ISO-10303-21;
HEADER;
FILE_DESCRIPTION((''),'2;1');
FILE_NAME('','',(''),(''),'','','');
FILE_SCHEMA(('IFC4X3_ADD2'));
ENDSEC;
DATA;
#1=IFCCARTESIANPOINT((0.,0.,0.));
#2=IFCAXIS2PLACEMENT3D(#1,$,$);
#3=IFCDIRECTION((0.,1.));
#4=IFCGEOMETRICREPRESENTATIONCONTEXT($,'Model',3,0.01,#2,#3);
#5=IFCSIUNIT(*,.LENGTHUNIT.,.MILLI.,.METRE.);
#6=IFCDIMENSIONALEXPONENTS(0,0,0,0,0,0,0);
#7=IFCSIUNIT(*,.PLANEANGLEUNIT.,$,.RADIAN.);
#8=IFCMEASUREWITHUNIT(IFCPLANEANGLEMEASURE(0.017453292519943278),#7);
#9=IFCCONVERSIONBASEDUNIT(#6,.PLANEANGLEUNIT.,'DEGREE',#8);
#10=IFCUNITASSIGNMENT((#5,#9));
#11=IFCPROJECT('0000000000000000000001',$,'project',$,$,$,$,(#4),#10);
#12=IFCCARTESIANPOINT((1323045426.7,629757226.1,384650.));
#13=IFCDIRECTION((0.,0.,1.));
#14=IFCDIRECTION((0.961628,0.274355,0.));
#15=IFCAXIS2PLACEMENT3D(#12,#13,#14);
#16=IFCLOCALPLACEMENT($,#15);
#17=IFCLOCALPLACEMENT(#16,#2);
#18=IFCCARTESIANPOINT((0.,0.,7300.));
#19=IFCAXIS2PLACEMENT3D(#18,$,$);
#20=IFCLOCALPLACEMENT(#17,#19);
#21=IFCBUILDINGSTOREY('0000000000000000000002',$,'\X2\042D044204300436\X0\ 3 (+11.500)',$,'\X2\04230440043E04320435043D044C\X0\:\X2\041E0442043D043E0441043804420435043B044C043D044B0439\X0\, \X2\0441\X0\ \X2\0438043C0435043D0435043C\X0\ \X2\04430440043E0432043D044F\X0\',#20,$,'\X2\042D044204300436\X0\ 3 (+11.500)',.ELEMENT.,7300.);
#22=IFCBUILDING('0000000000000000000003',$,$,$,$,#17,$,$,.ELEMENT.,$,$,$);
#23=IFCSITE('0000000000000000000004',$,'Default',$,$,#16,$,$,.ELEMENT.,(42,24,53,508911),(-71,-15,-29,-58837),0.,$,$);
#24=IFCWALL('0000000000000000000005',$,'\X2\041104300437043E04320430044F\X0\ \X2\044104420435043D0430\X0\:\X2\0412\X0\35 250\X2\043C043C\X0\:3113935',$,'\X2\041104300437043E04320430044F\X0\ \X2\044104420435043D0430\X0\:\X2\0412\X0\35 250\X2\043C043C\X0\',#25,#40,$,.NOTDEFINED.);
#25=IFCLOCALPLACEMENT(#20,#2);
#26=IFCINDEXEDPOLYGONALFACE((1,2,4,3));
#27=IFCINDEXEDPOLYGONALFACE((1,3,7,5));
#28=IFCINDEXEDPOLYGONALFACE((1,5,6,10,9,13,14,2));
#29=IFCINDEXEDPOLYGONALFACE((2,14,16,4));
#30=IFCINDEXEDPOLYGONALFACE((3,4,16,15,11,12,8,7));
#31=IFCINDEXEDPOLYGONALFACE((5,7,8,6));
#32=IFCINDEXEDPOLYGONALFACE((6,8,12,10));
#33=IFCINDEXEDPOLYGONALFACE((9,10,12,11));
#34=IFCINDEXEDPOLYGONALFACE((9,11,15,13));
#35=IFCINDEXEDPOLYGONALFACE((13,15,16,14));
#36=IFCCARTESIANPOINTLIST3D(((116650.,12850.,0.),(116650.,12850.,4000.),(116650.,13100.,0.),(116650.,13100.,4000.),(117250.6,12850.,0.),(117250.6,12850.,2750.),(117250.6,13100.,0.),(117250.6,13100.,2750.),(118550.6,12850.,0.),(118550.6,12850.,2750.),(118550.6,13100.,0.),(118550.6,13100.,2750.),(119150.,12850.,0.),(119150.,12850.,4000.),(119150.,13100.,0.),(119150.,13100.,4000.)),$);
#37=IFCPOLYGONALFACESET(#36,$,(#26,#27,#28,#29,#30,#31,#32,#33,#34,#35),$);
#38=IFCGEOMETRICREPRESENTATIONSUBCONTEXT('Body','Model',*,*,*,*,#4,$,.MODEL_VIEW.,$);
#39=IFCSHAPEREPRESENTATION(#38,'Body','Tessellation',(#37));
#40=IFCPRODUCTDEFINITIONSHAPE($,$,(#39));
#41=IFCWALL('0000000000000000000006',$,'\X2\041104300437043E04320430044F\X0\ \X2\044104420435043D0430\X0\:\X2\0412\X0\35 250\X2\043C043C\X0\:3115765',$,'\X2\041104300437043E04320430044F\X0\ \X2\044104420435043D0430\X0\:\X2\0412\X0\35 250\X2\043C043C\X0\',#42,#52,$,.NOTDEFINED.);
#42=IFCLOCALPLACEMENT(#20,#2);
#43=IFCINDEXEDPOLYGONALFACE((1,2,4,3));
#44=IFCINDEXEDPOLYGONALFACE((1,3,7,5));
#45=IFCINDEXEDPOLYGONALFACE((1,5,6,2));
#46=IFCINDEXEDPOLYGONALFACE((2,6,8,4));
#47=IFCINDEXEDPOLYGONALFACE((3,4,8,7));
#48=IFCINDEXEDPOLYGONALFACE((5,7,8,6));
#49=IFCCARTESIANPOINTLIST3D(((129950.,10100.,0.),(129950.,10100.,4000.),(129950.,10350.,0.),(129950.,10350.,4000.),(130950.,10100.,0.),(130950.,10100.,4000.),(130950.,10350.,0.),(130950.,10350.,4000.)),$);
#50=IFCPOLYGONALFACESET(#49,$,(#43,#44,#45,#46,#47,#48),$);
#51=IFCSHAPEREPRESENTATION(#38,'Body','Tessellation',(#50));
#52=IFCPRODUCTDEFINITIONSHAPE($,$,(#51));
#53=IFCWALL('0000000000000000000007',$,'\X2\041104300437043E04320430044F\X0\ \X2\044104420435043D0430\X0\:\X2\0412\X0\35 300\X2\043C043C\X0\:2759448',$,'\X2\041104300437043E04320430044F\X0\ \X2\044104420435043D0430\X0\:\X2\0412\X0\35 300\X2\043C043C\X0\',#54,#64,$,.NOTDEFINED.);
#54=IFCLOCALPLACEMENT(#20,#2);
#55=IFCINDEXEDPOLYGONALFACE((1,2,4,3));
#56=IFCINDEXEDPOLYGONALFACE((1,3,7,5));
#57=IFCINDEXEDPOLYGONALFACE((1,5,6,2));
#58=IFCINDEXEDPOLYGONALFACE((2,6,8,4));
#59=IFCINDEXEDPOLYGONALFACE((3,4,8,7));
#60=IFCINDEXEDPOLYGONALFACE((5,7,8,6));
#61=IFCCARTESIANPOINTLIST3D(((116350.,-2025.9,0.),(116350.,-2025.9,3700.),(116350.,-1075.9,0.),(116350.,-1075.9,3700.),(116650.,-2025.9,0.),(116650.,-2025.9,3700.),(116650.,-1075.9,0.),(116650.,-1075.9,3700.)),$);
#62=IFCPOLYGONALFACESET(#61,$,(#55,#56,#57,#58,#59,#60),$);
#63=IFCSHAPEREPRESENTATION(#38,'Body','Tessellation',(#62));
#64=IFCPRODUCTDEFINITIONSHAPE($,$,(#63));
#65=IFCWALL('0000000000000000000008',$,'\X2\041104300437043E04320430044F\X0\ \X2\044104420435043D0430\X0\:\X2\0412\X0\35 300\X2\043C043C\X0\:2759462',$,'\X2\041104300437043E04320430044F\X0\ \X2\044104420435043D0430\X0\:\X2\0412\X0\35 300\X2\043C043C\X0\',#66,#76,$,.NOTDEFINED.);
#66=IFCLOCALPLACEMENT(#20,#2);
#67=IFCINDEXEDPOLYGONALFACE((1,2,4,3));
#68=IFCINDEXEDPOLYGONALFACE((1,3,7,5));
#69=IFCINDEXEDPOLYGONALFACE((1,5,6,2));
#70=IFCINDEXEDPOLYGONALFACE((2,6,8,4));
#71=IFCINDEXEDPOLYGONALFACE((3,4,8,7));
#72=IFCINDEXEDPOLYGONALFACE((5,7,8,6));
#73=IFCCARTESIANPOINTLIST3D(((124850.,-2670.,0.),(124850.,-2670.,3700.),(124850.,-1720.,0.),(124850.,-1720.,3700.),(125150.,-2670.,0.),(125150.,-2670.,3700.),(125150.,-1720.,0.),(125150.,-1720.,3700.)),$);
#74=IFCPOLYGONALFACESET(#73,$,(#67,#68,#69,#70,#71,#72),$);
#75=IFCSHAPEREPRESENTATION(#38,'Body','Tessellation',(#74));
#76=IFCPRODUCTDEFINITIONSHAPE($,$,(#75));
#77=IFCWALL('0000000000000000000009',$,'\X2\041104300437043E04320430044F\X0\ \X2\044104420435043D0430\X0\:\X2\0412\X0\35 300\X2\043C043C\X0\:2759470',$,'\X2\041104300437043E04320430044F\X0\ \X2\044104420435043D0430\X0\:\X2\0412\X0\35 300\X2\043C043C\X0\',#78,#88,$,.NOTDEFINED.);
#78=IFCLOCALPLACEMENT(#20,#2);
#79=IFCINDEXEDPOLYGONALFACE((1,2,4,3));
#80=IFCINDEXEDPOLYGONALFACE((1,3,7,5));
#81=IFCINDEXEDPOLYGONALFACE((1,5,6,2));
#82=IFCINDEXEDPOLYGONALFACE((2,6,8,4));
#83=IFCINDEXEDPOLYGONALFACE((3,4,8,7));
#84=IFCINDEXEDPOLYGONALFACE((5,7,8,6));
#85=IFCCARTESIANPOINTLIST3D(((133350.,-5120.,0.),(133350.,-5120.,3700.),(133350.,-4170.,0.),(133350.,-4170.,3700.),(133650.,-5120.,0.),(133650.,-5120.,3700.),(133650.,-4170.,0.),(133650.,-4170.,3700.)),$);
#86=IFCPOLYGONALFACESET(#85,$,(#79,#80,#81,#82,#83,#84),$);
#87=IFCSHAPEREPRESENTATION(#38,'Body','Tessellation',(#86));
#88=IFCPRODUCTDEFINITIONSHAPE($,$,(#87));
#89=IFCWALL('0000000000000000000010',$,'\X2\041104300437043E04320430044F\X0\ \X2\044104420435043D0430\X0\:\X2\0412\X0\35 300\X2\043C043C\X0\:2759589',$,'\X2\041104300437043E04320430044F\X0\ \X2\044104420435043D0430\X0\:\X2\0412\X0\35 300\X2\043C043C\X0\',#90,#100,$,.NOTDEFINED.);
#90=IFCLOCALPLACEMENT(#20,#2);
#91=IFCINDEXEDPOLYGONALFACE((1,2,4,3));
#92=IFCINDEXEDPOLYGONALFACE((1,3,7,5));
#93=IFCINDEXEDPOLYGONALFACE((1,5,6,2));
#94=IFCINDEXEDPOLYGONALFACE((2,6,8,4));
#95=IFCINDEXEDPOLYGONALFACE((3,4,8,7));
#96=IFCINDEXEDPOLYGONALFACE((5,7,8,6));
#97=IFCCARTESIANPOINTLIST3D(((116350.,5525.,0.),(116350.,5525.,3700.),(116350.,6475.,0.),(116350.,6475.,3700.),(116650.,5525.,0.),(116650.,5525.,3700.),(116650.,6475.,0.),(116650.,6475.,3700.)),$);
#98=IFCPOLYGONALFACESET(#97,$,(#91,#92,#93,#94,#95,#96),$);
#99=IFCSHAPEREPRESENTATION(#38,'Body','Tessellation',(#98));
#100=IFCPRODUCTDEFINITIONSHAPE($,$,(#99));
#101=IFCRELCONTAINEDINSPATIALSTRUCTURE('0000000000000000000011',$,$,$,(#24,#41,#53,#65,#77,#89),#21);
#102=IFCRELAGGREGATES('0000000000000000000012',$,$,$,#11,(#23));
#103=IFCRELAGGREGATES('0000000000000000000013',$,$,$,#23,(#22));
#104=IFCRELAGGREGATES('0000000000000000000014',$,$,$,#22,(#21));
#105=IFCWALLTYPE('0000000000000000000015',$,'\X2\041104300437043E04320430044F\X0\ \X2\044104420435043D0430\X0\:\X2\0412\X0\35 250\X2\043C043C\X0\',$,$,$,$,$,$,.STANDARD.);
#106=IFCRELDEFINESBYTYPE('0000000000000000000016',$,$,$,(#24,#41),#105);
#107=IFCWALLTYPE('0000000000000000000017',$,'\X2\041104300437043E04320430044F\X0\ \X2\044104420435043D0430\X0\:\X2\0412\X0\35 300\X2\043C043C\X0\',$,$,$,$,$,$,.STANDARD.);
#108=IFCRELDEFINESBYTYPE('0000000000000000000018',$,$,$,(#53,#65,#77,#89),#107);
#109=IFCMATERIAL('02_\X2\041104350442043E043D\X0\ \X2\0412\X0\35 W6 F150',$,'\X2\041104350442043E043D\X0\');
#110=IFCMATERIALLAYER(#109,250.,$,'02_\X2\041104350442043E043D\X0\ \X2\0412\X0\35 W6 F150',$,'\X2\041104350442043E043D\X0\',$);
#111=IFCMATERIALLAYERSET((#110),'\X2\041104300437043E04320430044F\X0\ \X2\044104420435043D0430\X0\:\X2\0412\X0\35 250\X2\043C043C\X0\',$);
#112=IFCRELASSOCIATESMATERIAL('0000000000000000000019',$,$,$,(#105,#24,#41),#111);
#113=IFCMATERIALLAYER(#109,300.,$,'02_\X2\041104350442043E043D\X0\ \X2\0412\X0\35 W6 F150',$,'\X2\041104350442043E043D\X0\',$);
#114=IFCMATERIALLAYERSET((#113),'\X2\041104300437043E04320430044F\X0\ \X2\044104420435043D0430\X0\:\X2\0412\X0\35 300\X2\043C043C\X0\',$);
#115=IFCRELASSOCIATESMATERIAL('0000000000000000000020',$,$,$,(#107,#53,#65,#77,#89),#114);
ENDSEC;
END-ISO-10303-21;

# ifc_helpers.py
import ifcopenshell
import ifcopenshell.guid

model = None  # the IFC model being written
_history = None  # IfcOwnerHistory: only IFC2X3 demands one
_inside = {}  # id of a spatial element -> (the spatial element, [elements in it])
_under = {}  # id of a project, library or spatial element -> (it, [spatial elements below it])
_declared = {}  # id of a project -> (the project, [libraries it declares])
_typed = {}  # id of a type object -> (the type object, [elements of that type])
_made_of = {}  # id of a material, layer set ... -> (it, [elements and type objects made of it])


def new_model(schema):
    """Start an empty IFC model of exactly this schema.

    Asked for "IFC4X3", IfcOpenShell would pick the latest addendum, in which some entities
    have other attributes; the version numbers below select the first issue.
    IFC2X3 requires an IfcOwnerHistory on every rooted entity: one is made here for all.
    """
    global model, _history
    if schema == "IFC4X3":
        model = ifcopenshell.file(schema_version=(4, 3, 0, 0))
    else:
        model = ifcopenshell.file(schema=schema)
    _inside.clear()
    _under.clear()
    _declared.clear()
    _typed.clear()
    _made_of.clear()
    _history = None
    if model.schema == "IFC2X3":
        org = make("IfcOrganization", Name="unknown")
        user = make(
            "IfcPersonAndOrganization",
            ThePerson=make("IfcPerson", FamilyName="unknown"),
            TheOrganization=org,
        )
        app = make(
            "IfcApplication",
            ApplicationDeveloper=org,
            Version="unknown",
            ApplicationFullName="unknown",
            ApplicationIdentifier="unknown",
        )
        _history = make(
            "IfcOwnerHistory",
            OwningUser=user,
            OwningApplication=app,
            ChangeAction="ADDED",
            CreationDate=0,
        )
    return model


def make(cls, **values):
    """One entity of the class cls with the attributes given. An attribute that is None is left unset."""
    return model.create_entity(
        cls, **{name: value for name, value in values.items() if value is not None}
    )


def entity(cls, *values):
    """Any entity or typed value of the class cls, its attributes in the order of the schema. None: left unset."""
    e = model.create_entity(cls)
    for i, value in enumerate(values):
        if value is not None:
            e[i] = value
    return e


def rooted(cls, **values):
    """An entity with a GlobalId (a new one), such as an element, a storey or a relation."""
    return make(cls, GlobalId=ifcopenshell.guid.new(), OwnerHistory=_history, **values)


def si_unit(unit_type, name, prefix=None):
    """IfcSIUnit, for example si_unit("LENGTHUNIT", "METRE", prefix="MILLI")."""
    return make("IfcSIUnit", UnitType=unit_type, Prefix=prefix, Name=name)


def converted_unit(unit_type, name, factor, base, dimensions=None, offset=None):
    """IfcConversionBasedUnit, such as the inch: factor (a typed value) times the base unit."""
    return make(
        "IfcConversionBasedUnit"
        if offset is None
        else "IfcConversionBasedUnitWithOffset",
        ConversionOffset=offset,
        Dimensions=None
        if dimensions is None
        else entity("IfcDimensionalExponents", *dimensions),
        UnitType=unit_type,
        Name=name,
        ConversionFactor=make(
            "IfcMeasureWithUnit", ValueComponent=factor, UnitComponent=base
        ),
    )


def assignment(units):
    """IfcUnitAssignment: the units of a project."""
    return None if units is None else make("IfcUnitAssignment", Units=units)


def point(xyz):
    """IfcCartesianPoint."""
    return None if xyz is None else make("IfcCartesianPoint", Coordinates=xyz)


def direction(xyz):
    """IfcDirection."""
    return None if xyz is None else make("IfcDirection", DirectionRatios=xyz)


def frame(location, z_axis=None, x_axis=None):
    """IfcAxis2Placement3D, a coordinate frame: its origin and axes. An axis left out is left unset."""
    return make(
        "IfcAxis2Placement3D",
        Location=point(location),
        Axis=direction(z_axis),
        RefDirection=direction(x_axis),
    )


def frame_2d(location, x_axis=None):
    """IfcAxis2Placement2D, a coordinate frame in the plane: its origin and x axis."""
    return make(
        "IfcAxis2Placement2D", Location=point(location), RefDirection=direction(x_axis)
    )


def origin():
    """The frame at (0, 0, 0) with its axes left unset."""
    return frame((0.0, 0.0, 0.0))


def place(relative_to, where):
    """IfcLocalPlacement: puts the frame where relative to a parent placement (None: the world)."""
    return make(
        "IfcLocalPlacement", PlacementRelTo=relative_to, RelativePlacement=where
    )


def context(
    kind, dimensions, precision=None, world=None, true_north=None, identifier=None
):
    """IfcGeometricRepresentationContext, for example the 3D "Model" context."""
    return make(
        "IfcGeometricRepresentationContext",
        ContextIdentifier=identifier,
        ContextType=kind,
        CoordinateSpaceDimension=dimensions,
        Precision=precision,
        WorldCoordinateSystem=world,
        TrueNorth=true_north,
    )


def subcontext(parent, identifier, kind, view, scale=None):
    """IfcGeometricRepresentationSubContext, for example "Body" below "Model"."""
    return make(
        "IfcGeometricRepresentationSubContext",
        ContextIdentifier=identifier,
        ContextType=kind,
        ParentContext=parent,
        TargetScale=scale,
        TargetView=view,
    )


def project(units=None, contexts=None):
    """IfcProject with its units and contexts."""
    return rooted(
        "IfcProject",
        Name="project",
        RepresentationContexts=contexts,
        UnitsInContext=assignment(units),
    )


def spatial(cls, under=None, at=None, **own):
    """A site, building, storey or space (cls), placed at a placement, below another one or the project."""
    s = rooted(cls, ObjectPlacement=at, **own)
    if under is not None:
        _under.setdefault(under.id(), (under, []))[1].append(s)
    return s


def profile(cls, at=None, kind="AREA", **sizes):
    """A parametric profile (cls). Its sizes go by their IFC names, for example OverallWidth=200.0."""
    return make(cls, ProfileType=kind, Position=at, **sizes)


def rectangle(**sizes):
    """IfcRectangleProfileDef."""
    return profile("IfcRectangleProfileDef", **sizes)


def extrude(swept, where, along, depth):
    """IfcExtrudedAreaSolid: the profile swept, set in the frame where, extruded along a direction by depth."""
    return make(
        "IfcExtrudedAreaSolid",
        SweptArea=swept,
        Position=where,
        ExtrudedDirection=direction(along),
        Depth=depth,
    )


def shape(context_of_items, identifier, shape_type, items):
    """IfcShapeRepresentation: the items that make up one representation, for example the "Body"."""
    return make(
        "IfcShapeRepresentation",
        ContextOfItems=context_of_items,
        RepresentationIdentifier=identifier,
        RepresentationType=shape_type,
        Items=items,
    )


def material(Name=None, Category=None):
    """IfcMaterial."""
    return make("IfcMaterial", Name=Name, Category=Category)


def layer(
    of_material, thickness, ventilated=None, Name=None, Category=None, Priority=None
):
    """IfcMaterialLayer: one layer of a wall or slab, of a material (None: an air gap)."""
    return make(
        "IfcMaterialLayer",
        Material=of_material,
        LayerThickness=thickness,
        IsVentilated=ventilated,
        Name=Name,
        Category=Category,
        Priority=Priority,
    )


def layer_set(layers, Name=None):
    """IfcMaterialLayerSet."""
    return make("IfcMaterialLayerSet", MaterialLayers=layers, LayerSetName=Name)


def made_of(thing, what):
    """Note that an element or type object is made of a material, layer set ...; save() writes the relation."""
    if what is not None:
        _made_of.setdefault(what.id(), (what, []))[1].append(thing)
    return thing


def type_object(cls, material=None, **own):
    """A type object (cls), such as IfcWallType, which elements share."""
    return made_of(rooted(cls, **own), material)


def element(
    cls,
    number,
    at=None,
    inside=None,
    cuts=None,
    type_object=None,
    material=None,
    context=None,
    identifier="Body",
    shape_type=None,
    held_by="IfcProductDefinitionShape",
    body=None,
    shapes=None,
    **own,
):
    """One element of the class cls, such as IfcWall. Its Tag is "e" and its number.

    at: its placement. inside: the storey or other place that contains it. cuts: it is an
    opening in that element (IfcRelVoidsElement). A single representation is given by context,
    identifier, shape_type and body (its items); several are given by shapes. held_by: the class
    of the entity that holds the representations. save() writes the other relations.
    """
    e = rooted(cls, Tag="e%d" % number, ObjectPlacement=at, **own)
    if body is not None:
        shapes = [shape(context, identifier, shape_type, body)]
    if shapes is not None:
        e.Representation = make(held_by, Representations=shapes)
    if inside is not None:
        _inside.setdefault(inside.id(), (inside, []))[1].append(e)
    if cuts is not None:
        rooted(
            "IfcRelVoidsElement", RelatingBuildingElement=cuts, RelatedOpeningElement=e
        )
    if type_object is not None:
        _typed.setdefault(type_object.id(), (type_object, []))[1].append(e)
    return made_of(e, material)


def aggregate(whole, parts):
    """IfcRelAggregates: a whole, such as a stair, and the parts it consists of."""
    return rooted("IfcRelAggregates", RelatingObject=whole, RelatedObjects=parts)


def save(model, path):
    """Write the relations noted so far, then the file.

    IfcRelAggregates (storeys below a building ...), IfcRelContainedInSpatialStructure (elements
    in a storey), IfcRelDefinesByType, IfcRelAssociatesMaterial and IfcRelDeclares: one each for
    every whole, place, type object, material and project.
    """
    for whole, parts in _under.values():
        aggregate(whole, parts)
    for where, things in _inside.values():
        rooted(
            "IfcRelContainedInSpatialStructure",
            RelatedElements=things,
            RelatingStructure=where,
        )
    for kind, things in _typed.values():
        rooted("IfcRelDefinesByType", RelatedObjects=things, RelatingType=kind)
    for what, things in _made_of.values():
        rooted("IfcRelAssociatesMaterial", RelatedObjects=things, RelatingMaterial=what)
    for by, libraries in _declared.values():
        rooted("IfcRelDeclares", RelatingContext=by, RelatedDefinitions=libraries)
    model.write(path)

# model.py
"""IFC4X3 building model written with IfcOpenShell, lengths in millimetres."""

from ifc_helpers import new_model, entity, si_unit, converted_unit, direction, frame, frame_2d, origin, place, context, subcontext, project, spatial, rectangle, extrude, material, layer, layer_set, type_object, element, save


model = new_model("IFC4X3")

# Units and contexts
model_context = context("Model", 3, precision=0.01, world=origin(), true_north=direction((0.0, 1.0)))
body_context = subcontext(model_context, "Body", "Model", "MODEL_VIEW")
ifc_project = project(units=[si_unit("LENGTHUNIT", "METRE", prefix="MILLI"), converted_unit("PLANEANGLEUNIT", "DEGREE", entity("IfcPlaneAngleMeasure", 0.017453292519943278), si_unit("PLANEANGLEUNIT", "RADIAN"), dimensions=[0, 0, 0, 0, 0, 0, 0])], contexts=[model_context])

# Site, building, storey
site_placement = place(None, frame((1323045426.7, 629757226.1, 384650.0), z_axis=(0.0, 0.0, 1.0), x_axis=(0.961628, 0.274355, 0.0)))
site = spatial("IfcSite", under=ifc_project, at=site_placement, Name="Default", CompositionType="ELEMENT", RefLatitude=(42, 24, 53, 508911), RefLongitude=(-71, -15, -29, -58837), RefElevation=0.0)
building_placement = place(site_placement, origin())
building = spatial("IfcBuilding", under=site, at=building_placement, CompositionType="ELEMENT")
storey_placement = place(building_placement, frame((0.0, 0.0, 7300.0)))
storey = spatial("IfcBuildingStorey", under=building, at=storey_placement, Name="Этаж 3 (+11.500)", ObjectType="Уровень:Относительный, с именем уровня", LongName="Этаж 3 (+11.500)", CompositionType="ELEMENT", Elevation=7300.0)

# Shared definitions
ifc_material = material(Name="02_Бетон В35 W6 F150", Category="Бетон")
ifc_layer_1 = layer(ifc_material, 250.0, Name="02_Бетон В35 W6 F150", Category="Бетон")
ifc_layer_set_1 = layer_set([ifc_layer_1], Name="Базовая стена:В35 250мм")
wall_type_1 = type_object("IfcWallType", Name="Базовая стена:В35 250мм", PredefinedType="STANDARD", material=ifc_layer_set_1)

# Wall, opening
wall_1_placement = place(storey_placement, frame((116650.0, 12975.0, 0.0)))
wall_1 = element("IfcWall", 1, at=wall_1_placement, inside=storey, type_object=wall_type_1, material=ifc_layer_set_1, Name="Базовая стена:В35 250мм:3113935", ObjectType="Базовая стена:В35 250мм", PredefinedType="NOTDEFINED", context=body_context, shape_type="SweptSolid", body=[
    extrude(rectangle(XDim=2500.0, YDim=250.0, at=frame_2d((1250.0, 0.0), x_axis=(1.0, 0.0))), origin(), (0.0, 0.0, 1.0), 4000.0),
])
opening_1_placement = place(wall_1_placement, frame((-116650.0, -12975.0, 0.0)))
element("IfcOpeningElement", 2, at=opening_1_placement, cuts=wall_1, PredefinedType="OPENING", context=body_context, shape_type="SweptSolid", body=[
    extrude(rectangle(XDim=2750.0, YDim=1300.0, at=frame_2d((0.0, 0.0), x_axis=(1.0, 0.0))), frame((117900.6, 11326.0, 1375.0), z_axis=(0.0, 1.0, 0.0), x_axis=(0.0, 0.0, -1.0)), (0.0, 0.0, 1.0), 3048.0),
])

# Walls
wall_2_placement = place(storey_placement, frame((129950.0, 10225.0, 0.0)))
element("IfcWall", 3, at=wall_2_placement, inside=storey, type_object=wall_type_1, material=ifc_layer_set_1, Name="Базовая стена:В35 250мм:3115765", ObjectType="Базовая стена:В35 250мм", PredefinedType="NOTDEFINED", context=body_context, shape_type="SweptSolid", body=[
    extrude(rectangle(XDim=1000.0, YDim=250.0, at=frame_2d((500.0, 0.0), x_axis=(-1.0, 0.0))), origin(), (0.0, 0.0, 1.0), 4000.0),
])
ifc_layer_2 = layer(ifc_material, 300.0, Name="02_Бетон В35 W6 F150", Category="Бетон")
ifc_layer_set_2 = layer_set([ifc_layer_2], Name="Базовая стена:В35 300мм")
wall_type_2 = type_object("IfcWallType", Name="Базовая стена:В35 300мм", PredefinedType="STANDARD", material=ifc_layer_set_2)
for number, where, z_axis, x_axis, name in (
    (4, (116500.0, -2025.9, 0.0), (0.0, 0.0, 1.0), (0.0, 1.0, 0.0), "Базовая стена:В35 300мм:2759448"),
    (5, (125000.0, -2670.0, 0.0), (0.0, 0.0, 1.0), (0.0, 1.0, 0.0), "Базовая стена:В35 300мм:2759462"),
    (6, (133500.0, -5120.0, 0.0), (0.0, 0.0, 1.0), (0.0, 1.0, 0.0), "Базовая стена:В35 300мм:2759470"),
    (7, (116500.0, 5525.0, 0.0), (0.0, 0.0, 1.0), (0.0, 1.0, 0.0), "Базовая стена:В35 300мм:2759589"),
):
    element("IfcWall", number, at=place(storey_placement, frame(where, z_axis=z_axis, x_axis=x_axis)), inside=storey, type_object=wall_type_2, material=ifc_layer_set_2, Name=name, ObjectType="Базовая стена:В35 300мм", PredefinedType="NOTDEFINED", context=body_context, shape_type="SweptSolid", body=[
        extrude(rectangle(XDim=950.0, YDim=300.0, at=frame_2d((475.0, 0.0), x_axis=(-1.0, 0.0))), origin(), (0.0, 0.0, 1.0), 3700.0),
    ])

save(model, "model.ifc")
